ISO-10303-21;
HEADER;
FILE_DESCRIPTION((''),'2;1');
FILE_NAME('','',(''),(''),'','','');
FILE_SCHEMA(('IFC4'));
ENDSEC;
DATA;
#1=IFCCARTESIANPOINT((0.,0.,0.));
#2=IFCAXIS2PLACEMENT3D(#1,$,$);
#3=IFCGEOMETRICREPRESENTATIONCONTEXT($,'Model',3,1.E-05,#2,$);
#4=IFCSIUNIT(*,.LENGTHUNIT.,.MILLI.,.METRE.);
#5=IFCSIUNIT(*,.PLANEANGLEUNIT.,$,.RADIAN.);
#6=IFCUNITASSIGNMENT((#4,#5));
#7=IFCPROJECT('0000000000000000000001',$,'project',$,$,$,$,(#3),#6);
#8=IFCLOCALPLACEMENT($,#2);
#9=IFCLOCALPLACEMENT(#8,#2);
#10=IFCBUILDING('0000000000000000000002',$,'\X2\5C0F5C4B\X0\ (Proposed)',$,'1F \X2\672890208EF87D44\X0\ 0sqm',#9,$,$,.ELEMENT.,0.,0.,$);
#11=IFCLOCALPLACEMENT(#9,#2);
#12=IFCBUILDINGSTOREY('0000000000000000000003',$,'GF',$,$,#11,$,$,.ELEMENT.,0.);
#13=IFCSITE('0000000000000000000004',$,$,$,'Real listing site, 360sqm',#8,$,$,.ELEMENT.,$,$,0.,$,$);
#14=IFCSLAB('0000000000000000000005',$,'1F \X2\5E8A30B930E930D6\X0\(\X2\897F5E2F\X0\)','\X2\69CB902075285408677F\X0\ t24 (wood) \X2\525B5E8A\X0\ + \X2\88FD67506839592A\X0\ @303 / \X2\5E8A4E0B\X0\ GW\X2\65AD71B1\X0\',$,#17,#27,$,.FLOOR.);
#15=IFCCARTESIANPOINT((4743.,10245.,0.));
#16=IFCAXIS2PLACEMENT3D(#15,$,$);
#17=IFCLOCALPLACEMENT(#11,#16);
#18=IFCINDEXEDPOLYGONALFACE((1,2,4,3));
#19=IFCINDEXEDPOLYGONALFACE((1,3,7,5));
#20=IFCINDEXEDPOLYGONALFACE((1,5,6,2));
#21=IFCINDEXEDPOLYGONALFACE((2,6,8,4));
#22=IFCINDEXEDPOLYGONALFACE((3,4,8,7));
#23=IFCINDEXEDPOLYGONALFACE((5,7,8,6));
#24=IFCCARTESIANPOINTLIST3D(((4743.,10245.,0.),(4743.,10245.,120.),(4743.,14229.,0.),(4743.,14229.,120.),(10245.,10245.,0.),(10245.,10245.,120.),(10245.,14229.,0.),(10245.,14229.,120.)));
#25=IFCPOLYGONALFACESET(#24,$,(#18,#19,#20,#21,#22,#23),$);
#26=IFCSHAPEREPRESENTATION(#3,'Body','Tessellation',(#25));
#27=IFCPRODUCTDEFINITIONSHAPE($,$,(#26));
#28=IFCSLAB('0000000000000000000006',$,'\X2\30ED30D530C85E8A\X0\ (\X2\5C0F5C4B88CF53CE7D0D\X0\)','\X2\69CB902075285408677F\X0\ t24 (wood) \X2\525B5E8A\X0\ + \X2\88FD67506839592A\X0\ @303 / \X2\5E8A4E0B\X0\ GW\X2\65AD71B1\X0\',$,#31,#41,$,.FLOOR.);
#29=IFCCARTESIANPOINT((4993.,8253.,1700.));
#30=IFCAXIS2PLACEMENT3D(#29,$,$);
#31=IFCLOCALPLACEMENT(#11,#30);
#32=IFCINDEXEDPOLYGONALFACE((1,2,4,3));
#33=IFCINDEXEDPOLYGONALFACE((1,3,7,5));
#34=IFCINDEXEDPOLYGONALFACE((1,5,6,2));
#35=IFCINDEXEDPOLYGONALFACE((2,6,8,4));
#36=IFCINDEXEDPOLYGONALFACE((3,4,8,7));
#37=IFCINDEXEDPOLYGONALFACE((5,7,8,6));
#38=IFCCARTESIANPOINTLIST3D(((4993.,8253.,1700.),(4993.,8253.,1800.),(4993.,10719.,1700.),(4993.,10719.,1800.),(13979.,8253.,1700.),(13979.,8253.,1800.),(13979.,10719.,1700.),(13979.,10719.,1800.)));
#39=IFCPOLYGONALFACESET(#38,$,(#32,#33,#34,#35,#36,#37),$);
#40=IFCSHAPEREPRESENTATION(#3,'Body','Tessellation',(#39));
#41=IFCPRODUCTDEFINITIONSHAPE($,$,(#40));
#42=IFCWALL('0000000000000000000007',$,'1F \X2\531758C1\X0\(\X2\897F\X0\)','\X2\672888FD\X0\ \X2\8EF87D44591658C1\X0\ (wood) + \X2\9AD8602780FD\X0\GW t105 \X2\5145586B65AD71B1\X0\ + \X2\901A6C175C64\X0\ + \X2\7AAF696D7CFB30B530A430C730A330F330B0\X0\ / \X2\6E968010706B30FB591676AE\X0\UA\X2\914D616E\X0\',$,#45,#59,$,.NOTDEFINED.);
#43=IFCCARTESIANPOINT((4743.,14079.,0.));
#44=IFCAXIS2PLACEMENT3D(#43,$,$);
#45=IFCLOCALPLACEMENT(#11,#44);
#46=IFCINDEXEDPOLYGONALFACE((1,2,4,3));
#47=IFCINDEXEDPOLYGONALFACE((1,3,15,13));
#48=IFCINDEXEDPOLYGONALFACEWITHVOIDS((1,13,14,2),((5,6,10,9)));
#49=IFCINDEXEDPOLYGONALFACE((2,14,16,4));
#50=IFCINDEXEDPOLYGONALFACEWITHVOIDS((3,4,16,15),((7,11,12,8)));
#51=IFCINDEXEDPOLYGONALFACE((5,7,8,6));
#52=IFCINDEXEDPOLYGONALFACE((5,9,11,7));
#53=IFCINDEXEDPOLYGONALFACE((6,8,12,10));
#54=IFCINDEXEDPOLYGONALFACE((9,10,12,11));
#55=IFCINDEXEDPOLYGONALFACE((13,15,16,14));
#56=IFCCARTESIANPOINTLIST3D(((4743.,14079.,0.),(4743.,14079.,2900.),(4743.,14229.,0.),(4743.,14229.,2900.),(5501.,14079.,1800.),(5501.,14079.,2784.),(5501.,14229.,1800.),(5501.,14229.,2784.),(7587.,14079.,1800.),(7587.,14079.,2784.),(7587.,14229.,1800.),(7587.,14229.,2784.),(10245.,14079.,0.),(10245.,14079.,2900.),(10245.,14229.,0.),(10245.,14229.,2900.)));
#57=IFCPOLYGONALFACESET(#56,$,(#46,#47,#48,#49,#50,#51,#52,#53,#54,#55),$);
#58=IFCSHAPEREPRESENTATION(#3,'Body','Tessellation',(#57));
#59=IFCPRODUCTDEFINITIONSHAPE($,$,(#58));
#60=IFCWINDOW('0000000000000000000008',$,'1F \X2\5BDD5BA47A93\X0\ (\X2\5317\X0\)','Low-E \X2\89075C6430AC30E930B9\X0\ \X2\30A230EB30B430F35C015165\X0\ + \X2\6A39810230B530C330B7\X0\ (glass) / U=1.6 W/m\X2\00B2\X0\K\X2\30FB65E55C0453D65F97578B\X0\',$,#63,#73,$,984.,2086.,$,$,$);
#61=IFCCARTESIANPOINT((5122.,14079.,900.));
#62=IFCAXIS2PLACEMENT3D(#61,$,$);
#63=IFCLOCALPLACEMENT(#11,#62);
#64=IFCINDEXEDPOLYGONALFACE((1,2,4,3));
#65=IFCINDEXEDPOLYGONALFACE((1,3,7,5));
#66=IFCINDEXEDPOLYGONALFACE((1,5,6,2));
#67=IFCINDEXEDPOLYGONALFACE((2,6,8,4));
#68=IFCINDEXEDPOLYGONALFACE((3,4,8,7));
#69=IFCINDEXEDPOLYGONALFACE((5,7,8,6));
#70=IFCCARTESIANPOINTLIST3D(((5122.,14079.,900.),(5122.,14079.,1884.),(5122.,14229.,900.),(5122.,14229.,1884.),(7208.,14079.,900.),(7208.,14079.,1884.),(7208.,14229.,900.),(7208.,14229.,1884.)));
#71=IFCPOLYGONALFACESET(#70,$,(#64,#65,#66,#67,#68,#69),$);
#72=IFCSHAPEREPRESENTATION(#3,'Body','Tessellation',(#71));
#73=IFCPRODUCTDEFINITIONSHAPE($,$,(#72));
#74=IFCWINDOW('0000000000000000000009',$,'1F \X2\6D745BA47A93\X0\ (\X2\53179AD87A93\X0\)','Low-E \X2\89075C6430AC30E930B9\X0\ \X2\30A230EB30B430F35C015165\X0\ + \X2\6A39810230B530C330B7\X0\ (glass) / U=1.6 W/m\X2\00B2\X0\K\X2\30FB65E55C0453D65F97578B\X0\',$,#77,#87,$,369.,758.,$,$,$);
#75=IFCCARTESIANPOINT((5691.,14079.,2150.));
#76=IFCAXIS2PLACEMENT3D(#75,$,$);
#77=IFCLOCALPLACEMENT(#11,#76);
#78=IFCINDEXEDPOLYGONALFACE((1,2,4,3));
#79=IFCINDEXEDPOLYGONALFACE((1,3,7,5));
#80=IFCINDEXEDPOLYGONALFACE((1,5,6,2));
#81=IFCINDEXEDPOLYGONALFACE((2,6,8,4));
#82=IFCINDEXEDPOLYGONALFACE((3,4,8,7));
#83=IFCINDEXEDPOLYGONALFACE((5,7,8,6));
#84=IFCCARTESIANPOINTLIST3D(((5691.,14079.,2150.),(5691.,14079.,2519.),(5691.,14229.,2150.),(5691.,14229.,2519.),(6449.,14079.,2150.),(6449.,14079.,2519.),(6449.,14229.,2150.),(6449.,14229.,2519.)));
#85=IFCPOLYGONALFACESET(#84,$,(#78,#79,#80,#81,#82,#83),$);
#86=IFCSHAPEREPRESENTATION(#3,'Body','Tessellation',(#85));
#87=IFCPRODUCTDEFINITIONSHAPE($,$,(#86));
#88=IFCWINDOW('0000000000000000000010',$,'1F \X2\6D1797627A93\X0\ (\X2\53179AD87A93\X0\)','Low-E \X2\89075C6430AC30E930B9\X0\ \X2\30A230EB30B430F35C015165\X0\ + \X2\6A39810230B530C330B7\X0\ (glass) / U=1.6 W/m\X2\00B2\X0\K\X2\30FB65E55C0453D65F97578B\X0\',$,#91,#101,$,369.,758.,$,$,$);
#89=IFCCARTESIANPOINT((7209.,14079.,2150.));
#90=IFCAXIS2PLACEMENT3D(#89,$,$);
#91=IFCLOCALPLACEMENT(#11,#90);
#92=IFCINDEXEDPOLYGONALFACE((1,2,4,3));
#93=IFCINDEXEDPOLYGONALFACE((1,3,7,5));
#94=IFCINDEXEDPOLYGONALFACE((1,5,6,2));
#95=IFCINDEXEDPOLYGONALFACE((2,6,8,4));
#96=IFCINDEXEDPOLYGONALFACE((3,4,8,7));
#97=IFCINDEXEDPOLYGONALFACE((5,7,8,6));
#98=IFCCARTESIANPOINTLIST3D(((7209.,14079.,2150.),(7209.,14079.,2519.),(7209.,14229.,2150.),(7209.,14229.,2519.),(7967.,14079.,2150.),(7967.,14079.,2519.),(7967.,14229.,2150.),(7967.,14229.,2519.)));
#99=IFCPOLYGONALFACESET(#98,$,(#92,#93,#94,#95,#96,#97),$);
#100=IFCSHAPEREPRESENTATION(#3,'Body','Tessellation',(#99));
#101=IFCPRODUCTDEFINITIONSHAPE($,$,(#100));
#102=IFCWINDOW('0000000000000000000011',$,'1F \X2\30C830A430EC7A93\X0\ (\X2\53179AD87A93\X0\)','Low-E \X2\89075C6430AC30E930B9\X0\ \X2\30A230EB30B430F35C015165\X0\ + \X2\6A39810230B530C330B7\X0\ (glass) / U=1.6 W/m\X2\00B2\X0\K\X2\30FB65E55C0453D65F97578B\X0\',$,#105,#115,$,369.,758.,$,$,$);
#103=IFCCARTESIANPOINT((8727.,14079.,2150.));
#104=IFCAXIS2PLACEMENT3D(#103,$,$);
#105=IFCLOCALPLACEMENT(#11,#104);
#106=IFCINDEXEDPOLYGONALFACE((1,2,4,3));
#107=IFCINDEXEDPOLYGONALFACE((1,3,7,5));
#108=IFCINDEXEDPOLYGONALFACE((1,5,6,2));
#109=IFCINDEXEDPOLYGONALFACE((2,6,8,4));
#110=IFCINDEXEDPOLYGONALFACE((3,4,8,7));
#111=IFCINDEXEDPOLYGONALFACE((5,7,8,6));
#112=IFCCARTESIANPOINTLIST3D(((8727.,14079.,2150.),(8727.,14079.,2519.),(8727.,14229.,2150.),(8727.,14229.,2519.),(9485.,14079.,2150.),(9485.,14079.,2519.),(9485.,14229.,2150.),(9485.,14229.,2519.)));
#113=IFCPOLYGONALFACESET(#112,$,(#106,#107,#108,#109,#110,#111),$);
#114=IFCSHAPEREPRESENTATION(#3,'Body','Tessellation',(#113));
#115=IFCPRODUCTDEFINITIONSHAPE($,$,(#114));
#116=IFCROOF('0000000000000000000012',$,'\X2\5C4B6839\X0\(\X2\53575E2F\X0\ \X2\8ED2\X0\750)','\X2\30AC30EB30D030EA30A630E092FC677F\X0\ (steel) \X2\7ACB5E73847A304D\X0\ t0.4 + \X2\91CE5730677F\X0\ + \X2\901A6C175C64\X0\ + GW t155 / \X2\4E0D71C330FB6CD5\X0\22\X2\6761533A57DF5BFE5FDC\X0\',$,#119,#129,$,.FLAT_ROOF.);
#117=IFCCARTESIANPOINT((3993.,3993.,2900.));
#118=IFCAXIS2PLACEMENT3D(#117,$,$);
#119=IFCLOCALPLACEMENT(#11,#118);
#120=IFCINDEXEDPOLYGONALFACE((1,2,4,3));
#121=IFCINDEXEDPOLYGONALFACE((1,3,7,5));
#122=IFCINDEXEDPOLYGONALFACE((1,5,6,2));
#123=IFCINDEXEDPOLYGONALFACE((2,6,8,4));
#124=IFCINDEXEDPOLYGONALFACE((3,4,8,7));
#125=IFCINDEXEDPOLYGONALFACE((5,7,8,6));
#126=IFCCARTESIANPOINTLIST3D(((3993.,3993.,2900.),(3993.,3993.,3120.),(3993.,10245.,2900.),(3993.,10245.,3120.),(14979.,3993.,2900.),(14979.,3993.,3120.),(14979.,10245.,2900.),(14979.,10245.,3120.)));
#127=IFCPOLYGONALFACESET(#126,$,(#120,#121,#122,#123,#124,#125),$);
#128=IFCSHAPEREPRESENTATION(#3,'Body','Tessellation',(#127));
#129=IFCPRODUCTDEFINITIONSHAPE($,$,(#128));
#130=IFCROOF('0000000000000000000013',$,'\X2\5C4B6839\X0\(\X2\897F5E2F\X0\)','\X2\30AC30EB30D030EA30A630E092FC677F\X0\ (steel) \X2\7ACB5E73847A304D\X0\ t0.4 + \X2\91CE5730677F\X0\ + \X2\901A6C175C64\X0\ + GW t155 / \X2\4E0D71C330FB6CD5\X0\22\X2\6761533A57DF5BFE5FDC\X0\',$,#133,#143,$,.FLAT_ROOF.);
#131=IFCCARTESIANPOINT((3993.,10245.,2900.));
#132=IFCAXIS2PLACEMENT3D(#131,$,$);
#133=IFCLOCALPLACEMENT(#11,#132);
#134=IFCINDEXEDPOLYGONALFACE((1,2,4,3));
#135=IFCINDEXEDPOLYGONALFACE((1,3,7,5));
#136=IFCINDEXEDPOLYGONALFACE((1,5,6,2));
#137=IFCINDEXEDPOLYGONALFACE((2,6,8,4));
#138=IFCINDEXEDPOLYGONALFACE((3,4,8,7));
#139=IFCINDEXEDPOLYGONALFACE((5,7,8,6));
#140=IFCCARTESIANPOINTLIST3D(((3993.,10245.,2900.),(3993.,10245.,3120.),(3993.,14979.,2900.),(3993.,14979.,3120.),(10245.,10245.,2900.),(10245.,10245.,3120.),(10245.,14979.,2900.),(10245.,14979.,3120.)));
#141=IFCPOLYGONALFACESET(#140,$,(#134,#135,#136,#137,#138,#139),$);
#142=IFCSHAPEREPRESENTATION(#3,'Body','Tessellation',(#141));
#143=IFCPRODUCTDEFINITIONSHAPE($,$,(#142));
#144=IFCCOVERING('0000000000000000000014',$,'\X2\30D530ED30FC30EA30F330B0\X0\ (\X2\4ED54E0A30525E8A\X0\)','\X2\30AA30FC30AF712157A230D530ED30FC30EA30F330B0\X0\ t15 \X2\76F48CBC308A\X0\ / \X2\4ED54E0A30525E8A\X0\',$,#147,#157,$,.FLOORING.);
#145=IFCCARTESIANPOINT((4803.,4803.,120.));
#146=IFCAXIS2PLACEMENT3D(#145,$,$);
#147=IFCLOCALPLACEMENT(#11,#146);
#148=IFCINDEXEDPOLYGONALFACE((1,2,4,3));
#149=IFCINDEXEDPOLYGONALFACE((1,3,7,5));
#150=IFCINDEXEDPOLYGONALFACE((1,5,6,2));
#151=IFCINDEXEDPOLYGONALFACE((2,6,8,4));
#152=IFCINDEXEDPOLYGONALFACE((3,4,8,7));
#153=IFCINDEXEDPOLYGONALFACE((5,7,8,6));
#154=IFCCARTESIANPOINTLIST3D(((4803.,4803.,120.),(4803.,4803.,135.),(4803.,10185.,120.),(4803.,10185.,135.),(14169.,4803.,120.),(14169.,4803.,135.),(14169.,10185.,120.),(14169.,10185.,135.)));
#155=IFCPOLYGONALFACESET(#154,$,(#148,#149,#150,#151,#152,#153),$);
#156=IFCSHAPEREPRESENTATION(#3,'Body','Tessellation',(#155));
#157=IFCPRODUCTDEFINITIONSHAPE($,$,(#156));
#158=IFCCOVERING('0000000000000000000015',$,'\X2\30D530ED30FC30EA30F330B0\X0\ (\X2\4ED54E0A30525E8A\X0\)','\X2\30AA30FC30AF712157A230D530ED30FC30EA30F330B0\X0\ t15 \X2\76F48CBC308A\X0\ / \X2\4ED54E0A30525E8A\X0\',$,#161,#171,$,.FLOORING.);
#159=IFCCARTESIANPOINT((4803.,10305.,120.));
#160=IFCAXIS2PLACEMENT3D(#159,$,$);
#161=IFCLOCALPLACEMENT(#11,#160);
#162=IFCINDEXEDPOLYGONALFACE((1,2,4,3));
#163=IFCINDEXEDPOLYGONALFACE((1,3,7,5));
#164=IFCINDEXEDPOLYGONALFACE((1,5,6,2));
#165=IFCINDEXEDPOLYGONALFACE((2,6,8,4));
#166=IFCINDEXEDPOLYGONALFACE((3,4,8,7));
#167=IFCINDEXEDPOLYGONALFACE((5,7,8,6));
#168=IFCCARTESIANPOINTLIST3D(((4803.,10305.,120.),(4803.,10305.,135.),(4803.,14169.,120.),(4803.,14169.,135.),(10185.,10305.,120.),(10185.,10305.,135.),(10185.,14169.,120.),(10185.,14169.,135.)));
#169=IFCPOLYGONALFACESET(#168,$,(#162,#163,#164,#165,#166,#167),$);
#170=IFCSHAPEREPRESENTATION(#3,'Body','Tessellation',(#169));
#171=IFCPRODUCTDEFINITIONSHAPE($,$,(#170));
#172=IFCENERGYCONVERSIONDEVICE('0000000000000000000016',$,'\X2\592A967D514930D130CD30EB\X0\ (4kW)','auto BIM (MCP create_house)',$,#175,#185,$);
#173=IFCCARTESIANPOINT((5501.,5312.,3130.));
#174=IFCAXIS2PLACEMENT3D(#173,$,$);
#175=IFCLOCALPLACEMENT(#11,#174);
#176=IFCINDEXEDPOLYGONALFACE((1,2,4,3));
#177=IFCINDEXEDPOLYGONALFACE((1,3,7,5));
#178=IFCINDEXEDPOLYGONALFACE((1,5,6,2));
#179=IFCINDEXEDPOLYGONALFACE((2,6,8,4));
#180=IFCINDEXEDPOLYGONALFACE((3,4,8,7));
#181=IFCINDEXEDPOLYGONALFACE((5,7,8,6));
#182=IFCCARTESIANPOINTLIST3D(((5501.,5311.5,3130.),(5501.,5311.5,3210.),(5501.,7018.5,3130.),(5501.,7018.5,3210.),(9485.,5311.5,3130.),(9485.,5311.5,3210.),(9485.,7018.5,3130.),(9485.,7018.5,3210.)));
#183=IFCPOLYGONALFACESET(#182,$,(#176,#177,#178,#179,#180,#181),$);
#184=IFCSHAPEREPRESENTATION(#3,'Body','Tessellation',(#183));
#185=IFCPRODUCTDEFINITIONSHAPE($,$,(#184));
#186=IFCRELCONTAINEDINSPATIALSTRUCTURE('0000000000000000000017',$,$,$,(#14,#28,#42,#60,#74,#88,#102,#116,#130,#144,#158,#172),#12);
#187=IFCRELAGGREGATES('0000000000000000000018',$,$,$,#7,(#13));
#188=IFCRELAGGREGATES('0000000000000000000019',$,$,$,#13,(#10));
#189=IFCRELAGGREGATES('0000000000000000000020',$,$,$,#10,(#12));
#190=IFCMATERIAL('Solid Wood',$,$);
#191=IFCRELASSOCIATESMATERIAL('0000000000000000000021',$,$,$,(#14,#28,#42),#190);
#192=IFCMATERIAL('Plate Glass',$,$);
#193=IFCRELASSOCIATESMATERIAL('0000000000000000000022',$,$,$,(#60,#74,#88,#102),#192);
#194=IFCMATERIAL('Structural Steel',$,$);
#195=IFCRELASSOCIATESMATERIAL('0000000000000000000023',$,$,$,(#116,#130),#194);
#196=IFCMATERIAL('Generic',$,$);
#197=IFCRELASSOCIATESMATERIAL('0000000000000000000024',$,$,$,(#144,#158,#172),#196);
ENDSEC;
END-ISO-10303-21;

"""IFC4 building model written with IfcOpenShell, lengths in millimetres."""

from ifc_helpers import new_model, si_unit, frame, frame_2d, origin, place, context, project, spatial, rectangle, extrude, material, element, fill, save


model = new_model("IFC4")

# Units and contexts
model_context = context("Model", 3, precision=1e-05, world=origin())
ifc_project = project(units=[si_unit("LENGTHUNIT", "METRE", prefix="MILLI"), si_unit("PLANEANGLEUNIT", "RADIAN")], contexts=[model_context])

# Site, building, storey
site_placement = place(None, origin())
site = spatial("IfcSite", under=ifc_project, at=site_placement, ObjectType="Real listing site, 360sqm", CompositionType="ELEMENT", RefElevation=0.0)
building_placement = place(site_placement, origin())
building = spatial("IfcBuilding", under=site, at=building_placement, Name="小屋 (Proposed)", ObjectType="1F 木造軸組 0sqm", CompositionType="ELEMENT", ElevationOfRefHeight=0.0, ElevationOfTerrain=0.0)
storey_placement = place(building_placement, origin())
storey = spatial("IfcBuildingStorey", under=building, at=storey_placement, Name="GF", CompositionType="ELEMENT", Elevation=0.0)

# Slabs
ifc_material_1 = material(Name="Solid Wood")
slab_1_placement = place(storey_placement, frame((4743.0, 10245.0, 0.0)))
element("IfcSlab", 1, at=slab_1_placement, inside=storey, material=ifc_material_1, Name="1F 床スラブ(西帯)", Description="構造用合板 t24 (wood) 剛床 + 製材根太 @303 / 床下 GW断熱", PredefinedType="FLOOR", context=model_context, shape_type="SweptSolid", body=[
    extrude(rectangle(XDim=5502.0, YDim=3984.0, at=frame_2d((2751.0, 1992.0))), frame((4743.0, 10245.0, 0.0)), (0.0, 0.0, 1.0), 120.0),
])
slab_2_placement = place(storey_placement, frame((4993.0, 8253.0, 1700.0)))
element("IfcSlab", 2, at=slab_2_placement, inside=storey, material=ifc_material_1, Name="ロフト床 (小屋裏収納)", Description="構造用合板 t24 (wood) 剛床 + 製材根太 @303 / 床下 GW断熱", PredefinedType="FLOOR", context=model_context, shape_type="SweptSolid", body=[
    extrude(rectangle(XDim=8986.0, YDim=2466.0, at=frame_2d((4493.0, 1233.0))), frame((4993.0, 8253.0, 1700.0)), (0.0, 0.0, 1.0), 100.0),
])

# Shared definitions
ifc_material_2 = material(Name="Plate Glass")

# Wall, openings, windows
wall_1_placement = place(storey_placement, frame((4743.0, 14079.0, 0.0)))
wall_1 = element("IfcWall", 3, at=wall_1_placement, inside=storey, material=ifc_material_1, Name="1F 北壁(西)", Description="木製 軸組外壁 (wood) + 高性能GW t105 充填断熱 + 通気層 + 窯業系サイディング / 準耐火・外皮UA配慮", PredefinedType="NOTDEFINED", context=model_context, shape_type="SweptSolid", body=[
    extrude(rectangle(XDim=5502.0, YDim=150.0, at=frame_2d((2751.0, 75.0))), frame((4743.0, 14079.0, 0.0)), (0.0, 0.0, 1.0), 2900.0),
])
opening_1_placement = place(storey_placement, frame((5122.0, 14079.0, 900.0)))
opening_1 = element("IfcOpeningElement", 4, at=opening_1_placement, cuts=wall_1, PredefinedType="NOTDEFINED", context=model_context, shape_type="SweptSolid", body=[
    extrude(rectangle(XDim=2086.0, YDim=150.0, at=frame_2d((1043.0, 75.0))), frame((5122.0, 14079.0, 900.0)), (0.0, 0.0, 1.0), 984.0),
])
opening_2_placement = place(storey_placement, frame((5691.0, 14079.0, 2150.0)))
opening_2 = element("IfcOpeningElement", 5, at=opening_2_placement, cuts=wall_1, PredefinedType="NOTDEFINED", context=model_context, shape_type="SweptSolid", body=[
    extrude(rectangle(XDim=758.0, YDim=150.0, at=frame_2d((379.0, 75.0))), frame((5691.0, 14079.0, 2150.0)), (0.0, 0.0, 1.0), 369.0),
])
opening_3_placement = place(storey_placement, frame((7209.0, 14079.0, 2150.0)))
opening_3 = element("IfcOpeningElement", 6, at=opening_3_placement, cuts=wall_1, PredefinedType="NOTDEFINED", context=model_context, shape_type="SweptSolid", body=[
    extrude(rectangle(XDim=758.0, YDim=150.0, at=frame_2d((379.0, 75.0))), frame((7209.0, 14079.0, 2150.0)), (0.0, 0.0, 1.0), 369.0),
])
opening_4_placement = place(storey_placement, frame((8727.0, 14079.0, 2150.0)))
opening_4 = element("IfcOpeningElement", 7, at=opening_4_placement, cuts=wall_1, PredefinedType="NOTDEFINED", context=model_context, shape_type="SweptSolid", body=[
    extrude(rectangle(XDim=758.0, YDim=150.0, at=frame_2d((379.0, 75.0))), frame((8727.0, 14079.0, 2150.0)), (0.0, 0.0, 1.0), 369.0),
])
window_1_placement = place(storey_placement, frame((5122.0, 14079.0, 900.0)))
window_1 = element("IfcWindow", 8, at=window_1_placement, inside=storey, material=ifc_material_2, Name="1F 寝室窓 (北)", Description="Low-E 複層ガラス アルゴン封入 + 樹脂サッシ (glass) / U=1.6 W/m²K・日射取得型", OverallHeight=984.0, OverallWidth=2086.0, context=model_context, shape_type="SweptSolid", body=[
    extrude(rectangle(XDim=2086.0, YDim=150.0, at=frame_2d((1043.0, 75.0))), frame((5122.0, 14079.0, 900.0)), (0.0, 0.0, 1.0), 984.0),
])
fill(opening_1, window_1)
window_2_placement = place(storey_placement, frame((5691.0, 14079.0, 2150.0)))
window_2 = element("IfcWindow", 9, at=window_2_placement, inside=storey, material=ifc_material_2, Name="1F 浴室窓 (北高窓)", Description="Low-E 複層ガラス アルゴン封入 + 樹脂サッシ (glass) / U=1.6 W/m²K・日射取得型", OverallHeight=369.0, OverallWidth=758.0, context=model_context, shape_type="SweptSolid", body=[
    extrude(rectangle(XDim=758.0, YDim=150.0, at=frame_2d((379.0, 75.0))), frame((5691.0, 14079.0, 2150.0)), (0.0, 0.0, 1.0), 369.0),
])
fill(opening_2, window_2)
window_3_placement = place(storey_placement, frame((7209.0, 14079.0, 2150.0)))
window_3 = element("IfcWindow", 10, at=window_3_placement, inside=storey, material=ifc_material_2, Name="1F 洗面窓 (北高窓)", Description="Low-E 複層ガラス アルゴン封入 + 樹脂サッシ (glass) / U=1.6 W/m²K・日射取得型", OverallHeight=369.0, OverallWidth=758.0, context=model_context, shape_type="SweptSolid", body=[
    extrude(rectangle(XDim=758.0, YDim=150.0, at=frame_2d((379.0, 75.0))), frame((7209.0, 14079.0, 2150.0)), (0.0, 0.0, 1.0), 369.0),
])
fill(opening_3, window_3)
window_4_placement = place(storey_placement, frame((8727.0, 14079.0, 2150.0)))
window_4 = element("IfcWindow", 11, at=window_4_placement, inside=storey, material=ifc_material_2, Name="1F トイレ窓 (北高窓)", Description="Low-E 複層ガラス アルゴン封入 + 樹脂サッシ (glass) / U=1.6 W/m²K・日射取得型", OverallHeight=369.0, OverallWidth=758.0, context=model_context, shape_type="SweptSolid", body=[
    extrude(rectangle(XDim=758.0, YDim=150.0, at=frame_2d((379.0, 75.0))), frame((8727.0, 14079.0, 2150.0)), (0.0, 0.0, 1.0), 369.0),
])
fill(opening_4, window_4)

# Roofs
ifc_material_3 = material(Name="Structural Steel")
roof_1_placement = place(storey_placement, frame((3993.0, 3993.0, 2900.0)))
element("IfcRoof", 12, at=roof_1_placement, inside=storey, material=ifc_material_3, Name="屋根(南帯 軒750)", Description="ガルバリウム鋼板 (steel) 立平葺き t0.4 + 野地板 + 通気層 + GW t155 / 不燃・法22条区域対応", PredefinedType="FLAT_ROOF", context=model_context, shape_type="SweptSolid", body=[
    extrude(rectangle(XDim=10986.0, YDim=6252.0, at=frame_2d((5493.0, 3126.0))), frame((3993.0, 3993.0, 2900.0)), (0.0, 0.0, 1.0), 220.0),
])
roof_2_placement = place(storey_placement, frame((3993.0, 10245.0, 2900.0)))
element("IfcRoof", 13, at=roof_2_placement, inside=storey, material=ifc_material_3, Name="屋根(西帯)", Description="ガルバリウム鋼板 (steel) 立平葺き t0.4 + 野地板 + 通気層 + GW t155 / 不燃・法22条区域対応", PredefinedType="FLAT_ROOF", context=model_context, shape_type="SweptSolid", body=[
    extrude(rectangle(XDim=6252.0, YDim=4734.0, at=frame_2d((3126.0, 2367.0))), frame((3993.0, 10245.0, 2900.0)), (0.0, 0.0, 1.0), 220.0),
])

# Coverings
ifc_material_4 = material(Name="Generic")
covering_1_placement = place(storey_placement, frame((4803.0, 4803.0, 120.0)))
element("IfcCovering", 14, at=covering_1_placement, inside=storey, material=ifc_material_4, Name="フローリング (仕上げ床)", Description="オーク無垢フローリング t15 直貼り / 仕上げ床", PredefinedType="FLOORING", context=model_context, shape_type="SweptSolid", body=[
    extrude(rectangle(XDim=9366.0, YDim=5382.0, at=frame_2d((4683.0, 2691.0))), frame((4803.0, 4803.0, 120.0)), (0.0, 0.0, 1.0), 15.0),
])
covering_2_placement = place(storey_placement, frame((4803.0, 10305.0, 120.0)))
element("IfcCovering", 15, at=covering_2_placement, inside=storey, material=ifc_material_4, Name="フローリング (仕上げ床)", Description="オーク無垢フローリング t15 直貼り / 仕上げ床", PredefinedType="FLOORING", context=model_context, shape_type="SweptSolid", body=[
    extrude(rectangle(XDim=5382.0, YDim=3864.0, at=frame_2d((2691.0, 1932.0))), frame((4803.0, 10305.0, 120.0)), (0.0, 0.0, 1.0), 15.0),
])

# Energy conversion device
energy_conversion_device_placement = place(storey_placement, frame((5501.0, 5312.0, 3130.0)))
element("IfcEnergyConversionDevice", 16, at=energy_conversion_device_placement, inside=storey, material=ifc_material_4, Name="太陽光パネル (4kW)", Description="auto BIM (MCP create_house)", context=model_context, shape_type="SweptSolid", body=[
    extrude(rectangle(XDim=3984.0, YDim=1707.0, at=frame_2d((1992.0, 853.0))), frame((5501.0, 5312.0, 3130.0)), (0.0, 0.0, 1.0), 80.0),
])

save(model, "model.ifc")
